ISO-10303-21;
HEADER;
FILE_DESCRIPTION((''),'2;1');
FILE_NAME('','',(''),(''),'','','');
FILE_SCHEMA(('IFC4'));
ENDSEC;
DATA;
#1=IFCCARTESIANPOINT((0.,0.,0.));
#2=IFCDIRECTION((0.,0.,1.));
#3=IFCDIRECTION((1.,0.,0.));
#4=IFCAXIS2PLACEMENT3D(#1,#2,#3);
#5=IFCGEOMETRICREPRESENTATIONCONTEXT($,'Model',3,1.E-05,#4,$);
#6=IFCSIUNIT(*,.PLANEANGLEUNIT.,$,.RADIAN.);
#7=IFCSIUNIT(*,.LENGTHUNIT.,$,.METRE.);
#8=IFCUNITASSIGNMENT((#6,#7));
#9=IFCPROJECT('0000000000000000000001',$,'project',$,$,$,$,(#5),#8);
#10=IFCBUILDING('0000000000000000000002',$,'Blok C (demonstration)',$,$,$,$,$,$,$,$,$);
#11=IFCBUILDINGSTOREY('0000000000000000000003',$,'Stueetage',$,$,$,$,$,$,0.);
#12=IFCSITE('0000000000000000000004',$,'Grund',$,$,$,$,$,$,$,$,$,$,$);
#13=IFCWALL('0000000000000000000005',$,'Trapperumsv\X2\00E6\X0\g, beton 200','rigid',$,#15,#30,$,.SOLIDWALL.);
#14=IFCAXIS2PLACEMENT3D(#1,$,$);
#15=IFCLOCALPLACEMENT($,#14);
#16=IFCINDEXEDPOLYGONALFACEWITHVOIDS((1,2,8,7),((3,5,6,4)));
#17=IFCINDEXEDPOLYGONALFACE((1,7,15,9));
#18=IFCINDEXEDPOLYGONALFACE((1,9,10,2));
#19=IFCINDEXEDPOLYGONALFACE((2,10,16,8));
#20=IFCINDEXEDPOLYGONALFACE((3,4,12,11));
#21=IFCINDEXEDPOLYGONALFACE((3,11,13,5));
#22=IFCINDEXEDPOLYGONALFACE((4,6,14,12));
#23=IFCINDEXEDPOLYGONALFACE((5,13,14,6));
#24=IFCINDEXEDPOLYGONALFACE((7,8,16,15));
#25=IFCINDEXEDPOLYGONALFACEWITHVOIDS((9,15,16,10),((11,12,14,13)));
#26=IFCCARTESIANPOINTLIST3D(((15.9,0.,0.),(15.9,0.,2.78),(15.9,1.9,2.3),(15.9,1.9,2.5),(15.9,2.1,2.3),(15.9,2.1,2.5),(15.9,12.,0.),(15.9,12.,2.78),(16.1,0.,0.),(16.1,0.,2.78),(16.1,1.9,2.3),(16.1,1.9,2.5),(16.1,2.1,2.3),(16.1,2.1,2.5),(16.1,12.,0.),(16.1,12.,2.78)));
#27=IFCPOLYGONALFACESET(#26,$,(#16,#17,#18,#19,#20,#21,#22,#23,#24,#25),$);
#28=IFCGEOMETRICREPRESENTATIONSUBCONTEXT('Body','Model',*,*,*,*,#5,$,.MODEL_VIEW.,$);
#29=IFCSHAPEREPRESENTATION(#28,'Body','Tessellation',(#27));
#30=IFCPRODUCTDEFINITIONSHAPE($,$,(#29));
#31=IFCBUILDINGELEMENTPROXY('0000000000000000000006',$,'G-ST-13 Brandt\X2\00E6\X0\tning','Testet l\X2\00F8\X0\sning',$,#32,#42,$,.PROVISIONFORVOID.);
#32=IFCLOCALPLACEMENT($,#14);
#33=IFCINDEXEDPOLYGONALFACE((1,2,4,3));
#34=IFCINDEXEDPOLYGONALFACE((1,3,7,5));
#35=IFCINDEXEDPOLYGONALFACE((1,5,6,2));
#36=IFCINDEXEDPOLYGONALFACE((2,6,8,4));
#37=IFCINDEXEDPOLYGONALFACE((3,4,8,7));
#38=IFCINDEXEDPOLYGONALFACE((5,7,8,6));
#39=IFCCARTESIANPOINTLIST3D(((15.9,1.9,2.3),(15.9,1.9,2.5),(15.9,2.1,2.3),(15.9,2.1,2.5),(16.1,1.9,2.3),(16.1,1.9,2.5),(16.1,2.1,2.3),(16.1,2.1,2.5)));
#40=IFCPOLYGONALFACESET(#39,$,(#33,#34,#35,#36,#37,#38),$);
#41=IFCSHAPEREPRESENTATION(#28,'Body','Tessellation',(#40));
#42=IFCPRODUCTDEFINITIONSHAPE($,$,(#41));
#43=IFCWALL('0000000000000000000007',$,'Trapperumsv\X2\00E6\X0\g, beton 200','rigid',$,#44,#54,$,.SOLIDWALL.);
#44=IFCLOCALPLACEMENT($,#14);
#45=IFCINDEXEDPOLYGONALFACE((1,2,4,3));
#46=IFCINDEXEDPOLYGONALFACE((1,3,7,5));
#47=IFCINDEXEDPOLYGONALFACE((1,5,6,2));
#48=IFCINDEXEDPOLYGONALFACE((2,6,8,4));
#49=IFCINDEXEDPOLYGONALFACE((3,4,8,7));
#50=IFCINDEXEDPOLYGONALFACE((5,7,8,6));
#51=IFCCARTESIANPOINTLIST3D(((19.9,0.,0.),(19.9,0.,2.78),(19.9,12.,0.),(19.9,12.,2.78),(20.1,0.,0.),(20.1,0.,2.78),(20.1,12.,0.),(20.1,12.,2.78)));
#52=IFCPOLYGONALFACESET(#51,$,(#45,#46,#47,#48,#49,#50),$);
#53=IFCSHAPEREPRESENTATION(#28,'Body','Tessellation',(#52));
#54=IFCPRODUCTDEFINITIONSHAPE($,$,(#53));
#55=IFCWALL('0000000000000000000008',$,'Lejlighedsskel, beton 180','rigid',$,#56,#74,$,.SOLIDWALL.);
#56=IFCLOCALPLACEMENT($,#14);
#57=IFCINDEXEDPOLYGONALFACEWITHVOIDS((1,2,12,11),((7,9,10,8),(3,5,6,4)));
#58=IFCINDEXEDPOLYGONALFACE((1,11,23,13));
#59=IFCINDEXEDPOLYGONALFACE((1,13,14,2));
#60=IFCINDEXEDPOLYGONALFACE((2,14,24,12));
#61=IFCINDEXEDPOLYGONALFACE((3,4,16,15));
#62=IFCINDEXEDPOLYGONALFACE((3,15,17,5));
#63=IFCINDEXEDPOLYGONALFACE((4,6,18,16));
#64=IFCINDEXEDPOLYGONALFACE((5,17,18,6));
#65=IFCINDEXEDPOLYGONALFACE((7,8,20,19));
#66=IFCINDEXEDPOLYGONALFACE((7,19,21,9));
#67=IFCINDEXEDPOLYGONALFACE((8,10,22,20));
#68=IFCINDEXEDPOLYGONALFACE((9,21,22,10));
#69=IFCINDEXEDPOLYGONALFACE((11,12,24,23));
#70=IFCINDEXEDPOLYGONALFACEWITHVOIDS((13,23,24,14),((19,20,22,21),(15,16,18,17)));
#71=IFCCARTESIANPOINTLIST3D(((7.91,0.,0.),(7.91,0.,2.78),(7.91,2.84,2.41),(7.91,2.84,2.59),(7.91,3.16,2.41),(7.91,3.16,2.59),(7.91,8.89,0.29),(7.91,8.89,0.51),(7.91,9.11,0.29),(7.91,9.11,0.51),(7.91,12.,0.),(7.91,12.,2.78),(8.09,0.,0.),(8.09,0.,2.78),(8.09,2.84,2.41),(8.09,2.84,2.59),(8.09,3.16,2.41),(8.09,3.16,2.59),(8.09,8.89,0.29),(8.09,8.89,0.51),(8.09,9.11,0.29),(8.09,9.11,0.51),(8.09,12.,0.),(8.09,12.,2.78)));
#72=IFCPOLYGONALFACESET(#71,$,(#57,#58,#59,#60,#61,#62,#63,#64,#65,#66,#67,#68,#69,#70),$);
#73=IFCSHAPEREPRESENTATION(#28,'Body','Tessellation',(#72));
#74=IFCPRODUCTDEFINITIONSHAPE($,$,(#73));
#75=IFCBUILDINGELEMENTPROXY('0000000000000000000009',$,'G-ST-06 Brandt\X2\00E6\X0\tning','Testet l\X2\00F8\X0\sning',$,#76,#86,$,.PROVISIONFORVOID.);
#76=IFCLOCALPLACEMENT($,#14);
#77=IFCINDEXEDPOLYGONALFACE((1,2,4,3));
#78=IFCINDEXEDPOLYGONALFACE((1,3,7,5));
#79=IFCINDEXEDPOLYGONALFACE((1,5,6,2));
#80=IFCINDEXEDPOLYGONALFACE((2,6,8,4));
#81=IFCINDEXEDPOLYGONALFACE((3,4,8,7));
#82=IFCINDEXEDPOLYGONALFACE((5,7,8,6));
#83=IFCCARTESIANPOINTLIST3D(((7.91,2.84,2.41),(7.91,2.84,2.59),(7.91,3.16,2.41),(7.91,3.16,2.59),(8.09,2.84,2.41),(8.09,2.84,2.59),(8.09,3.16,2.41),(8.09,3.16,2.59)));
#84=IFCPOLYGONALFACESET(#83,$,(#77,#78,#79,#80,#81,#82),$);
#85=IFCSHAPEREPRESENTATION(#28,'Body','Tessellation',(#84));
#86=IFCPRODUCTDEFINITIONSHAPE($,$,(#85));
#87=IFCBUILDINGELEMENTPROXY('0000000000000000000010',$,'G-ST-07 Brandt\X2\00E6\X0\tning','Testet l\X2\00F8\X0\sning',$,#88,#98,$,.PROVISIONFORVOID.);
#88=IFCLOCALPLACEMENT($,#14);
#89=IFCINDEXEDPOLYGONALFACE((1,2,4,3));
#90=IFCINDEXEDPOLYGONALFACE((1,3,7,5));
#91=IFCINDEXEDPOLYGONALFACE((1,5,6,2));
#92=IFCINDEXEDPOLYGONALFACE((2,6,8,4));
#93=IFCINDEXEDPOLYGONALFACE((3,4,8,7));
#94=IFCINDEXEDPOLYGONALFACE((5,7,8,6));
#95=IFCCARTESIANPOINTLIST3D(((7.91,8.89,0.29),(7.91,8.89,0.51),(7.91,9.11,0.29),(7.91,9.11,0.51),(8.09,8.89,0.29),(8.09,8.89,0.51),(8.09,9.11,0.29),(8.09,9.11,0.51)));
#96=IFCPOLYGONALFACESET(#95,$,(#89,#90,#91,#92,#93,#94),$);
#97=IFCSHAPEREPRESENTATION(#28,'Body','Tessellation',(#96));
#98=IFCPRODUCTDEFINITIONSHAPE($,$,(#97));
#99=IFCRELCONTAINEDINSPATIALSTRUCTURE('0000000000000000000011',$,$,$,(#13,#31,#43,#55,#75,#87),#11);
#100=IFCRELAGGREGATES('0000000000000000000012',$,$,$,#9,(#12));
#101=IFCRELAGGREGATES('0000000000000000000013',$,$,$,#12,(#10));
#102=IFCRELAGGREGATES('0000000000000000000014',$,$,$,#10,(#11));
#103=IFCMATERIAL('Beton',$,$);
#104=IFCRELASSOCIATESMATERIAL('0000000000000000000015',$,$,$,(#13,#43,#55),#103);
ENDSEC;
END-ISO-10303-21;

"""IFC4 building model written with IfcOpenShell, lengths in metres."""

from ifc_helpers import new_model, si_unit, frame, origin, origin_with_axes, place, context, subcontext, project, spatial, polyline, outline, extrude, material, element, fill, save


model = new_model("IFC4")

# Units and contexts
model_context = context("Model", 3, precision=1e-05, world=origin_with_axes())
body_context = subcontext(model_context, "Body", "Model", "MODEL_VIEW")
ifc_project = project(units=[si_unit("PLANEANGLEUNIT", "RADIAN"), si_unit("LENGTHUNIT", "METRE")], contexts=[model_context])

# Site, building, storey
site = spatial("IfcSite", under=ifc_project, Name="Grund")
building = spatial("IfcBuilding", under=site, Name="Blok C (demonstration)")
storey = spatial("IfcBuildingStorey", under=building, Name="Stueetage", Elevation=0.0)

# Wall, opening, building element proxy
ifc_material_1 = material(Name="Beton")
wall_1_placement = place(None, origin_with_axes())
wall_1 = element("IfcWall", 1, at=wall_1_placement, inside=storey, material=ifc_material_1, Name="Trapperumsvæg, beton 200", Description="rigid", PredefinedType="SOLIDWALL", context=body_context, shape_type="SweptSolid", body=[
    extrude(outline(polyline([(15.9, 0.0), (16.1, 0.0), (16.1, 12.0), (15.9, 12.0), (15.9, 0.0)])), origin(), (0.0, 0.0, 1.0), 2.78),
])
opening_1_placement = place(wall_1_placement, origin_with_axes())
opening_1 = element("IfcOpeningElement", 2, at=opening_1_placement, cuts=wall_1, PredefinedType="OPENING", context=body_context, shape_type="SweptSolid", body=[
    extrude(outline(polyline([(15.88, 1.9), (16.12, 1.9), (16.12, 2.1), (15.88, 2.1), (15.88, 1.9)])), frame((0.0, 0.0, 2.3)), (0.0, 0.0, 1.0), 0.2),
])
proxy_1_placement = place(None, origin_with_axes())
proxy_1 = element("IfcBuildingElementProxy", 3, at=proxy_1_placement, inside=storey, Name="G-ST-13 Brandtætning", Description="Testet løsning", PredefinedType="PROVISIONFORVOID", context=body_context, shape_type="SweptSolid", body=[
    extrude(outline(polyline([(15.9, 1.9), (16.1, 1.9), (16.1, 2.1), (15.9, 2.1), (15.9, 1.9)])), frame((0.0, 0.0, 2.3)), (0.0, 0.0, 1.0), 0.2),
])
fill(opening_1, proxy_1)

# Wall
wall_2_placement = place(None, origin_with_axes())
element("IfcWall", 4, at=wall_2_placement, inside=storey, material=ifc_material_1, Name="Trapperumsvæg, beton 200", Description="rigid", PredefinedType="SOLIDWALL", context=body_context, shape_type="SweptSolid", body=[
    extrude(outline(polyline([(19.9, 0.0), (20.1, 0.0), (20.1, 12.0), (19.9, 12.0), (19.9, 0.0)])), origin(), (0.0, 0.0, 1.0), 2.78),
])

# Wall, openings, building element proxies
wall_3_placement = place(None, origin_with_axes())
wall_3 = element("IfcWall", 5, at=wall_3_placement, inside=storey, material=ifc_material_1, Name="Lejlighedsskel, beton 180", Description="rigid", PredefinedType="SOLIDWALL", context=body_context, shape_type="SweptSolid", body=[
    extrude(outline(polyline([(7.91, 0.0), (8.09, 0.0), (8.09, 12.0), (7.91, 12.0), (7.91, 0.0)])), origin(), (0.0, 0.0, 1.0), 2.78),
])
opening_2_placement = place(wall_3_placement, origin_with_axes())
opening_2 = element("IfcOpeningElement", 6, at=opening_2_placement, cuts=wall_3, PredefinedType="OPENING", context=body_context, shape_type="SweptSolid", body=[
    extrude(outline(polyline([(7.88, 2.84), (8.12, 2.84), (8.12, 3.16), (7.88, 3.16), (7.88, 2.84)])), frame((0.0, 0.0, 2.41)), (0.0, 0.0, 1.0), 0.18),
])
opening_3_placement = place(wall_3_placement, origin_with_axes())
opening_3 = element("IfcOpeningElement", 7, at=opening_3_placement, cuts=wall_3, PredefinedType="OPENING", context=body_context, shape_type="SweptSolid", body=[
    extrude(outline(polyline([(7.88, 8.89), (8.12, 8.89), (8.12, 9.11), (7.88, 9.11), (7.88, 8.89)])), frame((0.0, 0.0, 0.29)), (0.0, 0.0, 1.0), 0.22),
])
proxy_2_placement = place(None, origin_with_axes())
proxy_2 = element("IfcBuildingElementProxy", 8, at=proxy_2_placement, inside=storey, Name="G-ST-06 Brandtætning", Description="Testet løsning", PredefinedType="PROVISIONFORVOID", context=body_context, shape_type="SweptSolid", body=[
    extrude(outline(polyline([(7.91, 2.84), (8.09, 2.84), (8.09, 3.16), (7.91, 3.16), (7.91, 2.84)])), frame((0.0, 0.0, 2.41)), (0.0, 0.0, 1.0), 0.18),
])
fill(opening_2, proxy_2)
proxy_3_placement = place(None, origin_with_axes())
proxy_3 = element("IfcBuildingElementProxy", 9, at=proxy_3_placement, inside=storey, Name="G-ST-07 Brandtætning", Description="Testet løsning", PredefinedType="PROVISIONFORVOID", context=body_context, shape_type="SweptSolid", body=[
    extrude(outline(polyline([(7.91, 8.89), (8.09, 8.89), (8.09, 9.11), (7.91, 9.11), (7.91, 8.89)])), frame((0.0, 0.0, 0.29)), (0.0, 0.0, 1.0), 0.22),
])
fill(opening_3, proxy_3)

save(model, "model.ifc")
